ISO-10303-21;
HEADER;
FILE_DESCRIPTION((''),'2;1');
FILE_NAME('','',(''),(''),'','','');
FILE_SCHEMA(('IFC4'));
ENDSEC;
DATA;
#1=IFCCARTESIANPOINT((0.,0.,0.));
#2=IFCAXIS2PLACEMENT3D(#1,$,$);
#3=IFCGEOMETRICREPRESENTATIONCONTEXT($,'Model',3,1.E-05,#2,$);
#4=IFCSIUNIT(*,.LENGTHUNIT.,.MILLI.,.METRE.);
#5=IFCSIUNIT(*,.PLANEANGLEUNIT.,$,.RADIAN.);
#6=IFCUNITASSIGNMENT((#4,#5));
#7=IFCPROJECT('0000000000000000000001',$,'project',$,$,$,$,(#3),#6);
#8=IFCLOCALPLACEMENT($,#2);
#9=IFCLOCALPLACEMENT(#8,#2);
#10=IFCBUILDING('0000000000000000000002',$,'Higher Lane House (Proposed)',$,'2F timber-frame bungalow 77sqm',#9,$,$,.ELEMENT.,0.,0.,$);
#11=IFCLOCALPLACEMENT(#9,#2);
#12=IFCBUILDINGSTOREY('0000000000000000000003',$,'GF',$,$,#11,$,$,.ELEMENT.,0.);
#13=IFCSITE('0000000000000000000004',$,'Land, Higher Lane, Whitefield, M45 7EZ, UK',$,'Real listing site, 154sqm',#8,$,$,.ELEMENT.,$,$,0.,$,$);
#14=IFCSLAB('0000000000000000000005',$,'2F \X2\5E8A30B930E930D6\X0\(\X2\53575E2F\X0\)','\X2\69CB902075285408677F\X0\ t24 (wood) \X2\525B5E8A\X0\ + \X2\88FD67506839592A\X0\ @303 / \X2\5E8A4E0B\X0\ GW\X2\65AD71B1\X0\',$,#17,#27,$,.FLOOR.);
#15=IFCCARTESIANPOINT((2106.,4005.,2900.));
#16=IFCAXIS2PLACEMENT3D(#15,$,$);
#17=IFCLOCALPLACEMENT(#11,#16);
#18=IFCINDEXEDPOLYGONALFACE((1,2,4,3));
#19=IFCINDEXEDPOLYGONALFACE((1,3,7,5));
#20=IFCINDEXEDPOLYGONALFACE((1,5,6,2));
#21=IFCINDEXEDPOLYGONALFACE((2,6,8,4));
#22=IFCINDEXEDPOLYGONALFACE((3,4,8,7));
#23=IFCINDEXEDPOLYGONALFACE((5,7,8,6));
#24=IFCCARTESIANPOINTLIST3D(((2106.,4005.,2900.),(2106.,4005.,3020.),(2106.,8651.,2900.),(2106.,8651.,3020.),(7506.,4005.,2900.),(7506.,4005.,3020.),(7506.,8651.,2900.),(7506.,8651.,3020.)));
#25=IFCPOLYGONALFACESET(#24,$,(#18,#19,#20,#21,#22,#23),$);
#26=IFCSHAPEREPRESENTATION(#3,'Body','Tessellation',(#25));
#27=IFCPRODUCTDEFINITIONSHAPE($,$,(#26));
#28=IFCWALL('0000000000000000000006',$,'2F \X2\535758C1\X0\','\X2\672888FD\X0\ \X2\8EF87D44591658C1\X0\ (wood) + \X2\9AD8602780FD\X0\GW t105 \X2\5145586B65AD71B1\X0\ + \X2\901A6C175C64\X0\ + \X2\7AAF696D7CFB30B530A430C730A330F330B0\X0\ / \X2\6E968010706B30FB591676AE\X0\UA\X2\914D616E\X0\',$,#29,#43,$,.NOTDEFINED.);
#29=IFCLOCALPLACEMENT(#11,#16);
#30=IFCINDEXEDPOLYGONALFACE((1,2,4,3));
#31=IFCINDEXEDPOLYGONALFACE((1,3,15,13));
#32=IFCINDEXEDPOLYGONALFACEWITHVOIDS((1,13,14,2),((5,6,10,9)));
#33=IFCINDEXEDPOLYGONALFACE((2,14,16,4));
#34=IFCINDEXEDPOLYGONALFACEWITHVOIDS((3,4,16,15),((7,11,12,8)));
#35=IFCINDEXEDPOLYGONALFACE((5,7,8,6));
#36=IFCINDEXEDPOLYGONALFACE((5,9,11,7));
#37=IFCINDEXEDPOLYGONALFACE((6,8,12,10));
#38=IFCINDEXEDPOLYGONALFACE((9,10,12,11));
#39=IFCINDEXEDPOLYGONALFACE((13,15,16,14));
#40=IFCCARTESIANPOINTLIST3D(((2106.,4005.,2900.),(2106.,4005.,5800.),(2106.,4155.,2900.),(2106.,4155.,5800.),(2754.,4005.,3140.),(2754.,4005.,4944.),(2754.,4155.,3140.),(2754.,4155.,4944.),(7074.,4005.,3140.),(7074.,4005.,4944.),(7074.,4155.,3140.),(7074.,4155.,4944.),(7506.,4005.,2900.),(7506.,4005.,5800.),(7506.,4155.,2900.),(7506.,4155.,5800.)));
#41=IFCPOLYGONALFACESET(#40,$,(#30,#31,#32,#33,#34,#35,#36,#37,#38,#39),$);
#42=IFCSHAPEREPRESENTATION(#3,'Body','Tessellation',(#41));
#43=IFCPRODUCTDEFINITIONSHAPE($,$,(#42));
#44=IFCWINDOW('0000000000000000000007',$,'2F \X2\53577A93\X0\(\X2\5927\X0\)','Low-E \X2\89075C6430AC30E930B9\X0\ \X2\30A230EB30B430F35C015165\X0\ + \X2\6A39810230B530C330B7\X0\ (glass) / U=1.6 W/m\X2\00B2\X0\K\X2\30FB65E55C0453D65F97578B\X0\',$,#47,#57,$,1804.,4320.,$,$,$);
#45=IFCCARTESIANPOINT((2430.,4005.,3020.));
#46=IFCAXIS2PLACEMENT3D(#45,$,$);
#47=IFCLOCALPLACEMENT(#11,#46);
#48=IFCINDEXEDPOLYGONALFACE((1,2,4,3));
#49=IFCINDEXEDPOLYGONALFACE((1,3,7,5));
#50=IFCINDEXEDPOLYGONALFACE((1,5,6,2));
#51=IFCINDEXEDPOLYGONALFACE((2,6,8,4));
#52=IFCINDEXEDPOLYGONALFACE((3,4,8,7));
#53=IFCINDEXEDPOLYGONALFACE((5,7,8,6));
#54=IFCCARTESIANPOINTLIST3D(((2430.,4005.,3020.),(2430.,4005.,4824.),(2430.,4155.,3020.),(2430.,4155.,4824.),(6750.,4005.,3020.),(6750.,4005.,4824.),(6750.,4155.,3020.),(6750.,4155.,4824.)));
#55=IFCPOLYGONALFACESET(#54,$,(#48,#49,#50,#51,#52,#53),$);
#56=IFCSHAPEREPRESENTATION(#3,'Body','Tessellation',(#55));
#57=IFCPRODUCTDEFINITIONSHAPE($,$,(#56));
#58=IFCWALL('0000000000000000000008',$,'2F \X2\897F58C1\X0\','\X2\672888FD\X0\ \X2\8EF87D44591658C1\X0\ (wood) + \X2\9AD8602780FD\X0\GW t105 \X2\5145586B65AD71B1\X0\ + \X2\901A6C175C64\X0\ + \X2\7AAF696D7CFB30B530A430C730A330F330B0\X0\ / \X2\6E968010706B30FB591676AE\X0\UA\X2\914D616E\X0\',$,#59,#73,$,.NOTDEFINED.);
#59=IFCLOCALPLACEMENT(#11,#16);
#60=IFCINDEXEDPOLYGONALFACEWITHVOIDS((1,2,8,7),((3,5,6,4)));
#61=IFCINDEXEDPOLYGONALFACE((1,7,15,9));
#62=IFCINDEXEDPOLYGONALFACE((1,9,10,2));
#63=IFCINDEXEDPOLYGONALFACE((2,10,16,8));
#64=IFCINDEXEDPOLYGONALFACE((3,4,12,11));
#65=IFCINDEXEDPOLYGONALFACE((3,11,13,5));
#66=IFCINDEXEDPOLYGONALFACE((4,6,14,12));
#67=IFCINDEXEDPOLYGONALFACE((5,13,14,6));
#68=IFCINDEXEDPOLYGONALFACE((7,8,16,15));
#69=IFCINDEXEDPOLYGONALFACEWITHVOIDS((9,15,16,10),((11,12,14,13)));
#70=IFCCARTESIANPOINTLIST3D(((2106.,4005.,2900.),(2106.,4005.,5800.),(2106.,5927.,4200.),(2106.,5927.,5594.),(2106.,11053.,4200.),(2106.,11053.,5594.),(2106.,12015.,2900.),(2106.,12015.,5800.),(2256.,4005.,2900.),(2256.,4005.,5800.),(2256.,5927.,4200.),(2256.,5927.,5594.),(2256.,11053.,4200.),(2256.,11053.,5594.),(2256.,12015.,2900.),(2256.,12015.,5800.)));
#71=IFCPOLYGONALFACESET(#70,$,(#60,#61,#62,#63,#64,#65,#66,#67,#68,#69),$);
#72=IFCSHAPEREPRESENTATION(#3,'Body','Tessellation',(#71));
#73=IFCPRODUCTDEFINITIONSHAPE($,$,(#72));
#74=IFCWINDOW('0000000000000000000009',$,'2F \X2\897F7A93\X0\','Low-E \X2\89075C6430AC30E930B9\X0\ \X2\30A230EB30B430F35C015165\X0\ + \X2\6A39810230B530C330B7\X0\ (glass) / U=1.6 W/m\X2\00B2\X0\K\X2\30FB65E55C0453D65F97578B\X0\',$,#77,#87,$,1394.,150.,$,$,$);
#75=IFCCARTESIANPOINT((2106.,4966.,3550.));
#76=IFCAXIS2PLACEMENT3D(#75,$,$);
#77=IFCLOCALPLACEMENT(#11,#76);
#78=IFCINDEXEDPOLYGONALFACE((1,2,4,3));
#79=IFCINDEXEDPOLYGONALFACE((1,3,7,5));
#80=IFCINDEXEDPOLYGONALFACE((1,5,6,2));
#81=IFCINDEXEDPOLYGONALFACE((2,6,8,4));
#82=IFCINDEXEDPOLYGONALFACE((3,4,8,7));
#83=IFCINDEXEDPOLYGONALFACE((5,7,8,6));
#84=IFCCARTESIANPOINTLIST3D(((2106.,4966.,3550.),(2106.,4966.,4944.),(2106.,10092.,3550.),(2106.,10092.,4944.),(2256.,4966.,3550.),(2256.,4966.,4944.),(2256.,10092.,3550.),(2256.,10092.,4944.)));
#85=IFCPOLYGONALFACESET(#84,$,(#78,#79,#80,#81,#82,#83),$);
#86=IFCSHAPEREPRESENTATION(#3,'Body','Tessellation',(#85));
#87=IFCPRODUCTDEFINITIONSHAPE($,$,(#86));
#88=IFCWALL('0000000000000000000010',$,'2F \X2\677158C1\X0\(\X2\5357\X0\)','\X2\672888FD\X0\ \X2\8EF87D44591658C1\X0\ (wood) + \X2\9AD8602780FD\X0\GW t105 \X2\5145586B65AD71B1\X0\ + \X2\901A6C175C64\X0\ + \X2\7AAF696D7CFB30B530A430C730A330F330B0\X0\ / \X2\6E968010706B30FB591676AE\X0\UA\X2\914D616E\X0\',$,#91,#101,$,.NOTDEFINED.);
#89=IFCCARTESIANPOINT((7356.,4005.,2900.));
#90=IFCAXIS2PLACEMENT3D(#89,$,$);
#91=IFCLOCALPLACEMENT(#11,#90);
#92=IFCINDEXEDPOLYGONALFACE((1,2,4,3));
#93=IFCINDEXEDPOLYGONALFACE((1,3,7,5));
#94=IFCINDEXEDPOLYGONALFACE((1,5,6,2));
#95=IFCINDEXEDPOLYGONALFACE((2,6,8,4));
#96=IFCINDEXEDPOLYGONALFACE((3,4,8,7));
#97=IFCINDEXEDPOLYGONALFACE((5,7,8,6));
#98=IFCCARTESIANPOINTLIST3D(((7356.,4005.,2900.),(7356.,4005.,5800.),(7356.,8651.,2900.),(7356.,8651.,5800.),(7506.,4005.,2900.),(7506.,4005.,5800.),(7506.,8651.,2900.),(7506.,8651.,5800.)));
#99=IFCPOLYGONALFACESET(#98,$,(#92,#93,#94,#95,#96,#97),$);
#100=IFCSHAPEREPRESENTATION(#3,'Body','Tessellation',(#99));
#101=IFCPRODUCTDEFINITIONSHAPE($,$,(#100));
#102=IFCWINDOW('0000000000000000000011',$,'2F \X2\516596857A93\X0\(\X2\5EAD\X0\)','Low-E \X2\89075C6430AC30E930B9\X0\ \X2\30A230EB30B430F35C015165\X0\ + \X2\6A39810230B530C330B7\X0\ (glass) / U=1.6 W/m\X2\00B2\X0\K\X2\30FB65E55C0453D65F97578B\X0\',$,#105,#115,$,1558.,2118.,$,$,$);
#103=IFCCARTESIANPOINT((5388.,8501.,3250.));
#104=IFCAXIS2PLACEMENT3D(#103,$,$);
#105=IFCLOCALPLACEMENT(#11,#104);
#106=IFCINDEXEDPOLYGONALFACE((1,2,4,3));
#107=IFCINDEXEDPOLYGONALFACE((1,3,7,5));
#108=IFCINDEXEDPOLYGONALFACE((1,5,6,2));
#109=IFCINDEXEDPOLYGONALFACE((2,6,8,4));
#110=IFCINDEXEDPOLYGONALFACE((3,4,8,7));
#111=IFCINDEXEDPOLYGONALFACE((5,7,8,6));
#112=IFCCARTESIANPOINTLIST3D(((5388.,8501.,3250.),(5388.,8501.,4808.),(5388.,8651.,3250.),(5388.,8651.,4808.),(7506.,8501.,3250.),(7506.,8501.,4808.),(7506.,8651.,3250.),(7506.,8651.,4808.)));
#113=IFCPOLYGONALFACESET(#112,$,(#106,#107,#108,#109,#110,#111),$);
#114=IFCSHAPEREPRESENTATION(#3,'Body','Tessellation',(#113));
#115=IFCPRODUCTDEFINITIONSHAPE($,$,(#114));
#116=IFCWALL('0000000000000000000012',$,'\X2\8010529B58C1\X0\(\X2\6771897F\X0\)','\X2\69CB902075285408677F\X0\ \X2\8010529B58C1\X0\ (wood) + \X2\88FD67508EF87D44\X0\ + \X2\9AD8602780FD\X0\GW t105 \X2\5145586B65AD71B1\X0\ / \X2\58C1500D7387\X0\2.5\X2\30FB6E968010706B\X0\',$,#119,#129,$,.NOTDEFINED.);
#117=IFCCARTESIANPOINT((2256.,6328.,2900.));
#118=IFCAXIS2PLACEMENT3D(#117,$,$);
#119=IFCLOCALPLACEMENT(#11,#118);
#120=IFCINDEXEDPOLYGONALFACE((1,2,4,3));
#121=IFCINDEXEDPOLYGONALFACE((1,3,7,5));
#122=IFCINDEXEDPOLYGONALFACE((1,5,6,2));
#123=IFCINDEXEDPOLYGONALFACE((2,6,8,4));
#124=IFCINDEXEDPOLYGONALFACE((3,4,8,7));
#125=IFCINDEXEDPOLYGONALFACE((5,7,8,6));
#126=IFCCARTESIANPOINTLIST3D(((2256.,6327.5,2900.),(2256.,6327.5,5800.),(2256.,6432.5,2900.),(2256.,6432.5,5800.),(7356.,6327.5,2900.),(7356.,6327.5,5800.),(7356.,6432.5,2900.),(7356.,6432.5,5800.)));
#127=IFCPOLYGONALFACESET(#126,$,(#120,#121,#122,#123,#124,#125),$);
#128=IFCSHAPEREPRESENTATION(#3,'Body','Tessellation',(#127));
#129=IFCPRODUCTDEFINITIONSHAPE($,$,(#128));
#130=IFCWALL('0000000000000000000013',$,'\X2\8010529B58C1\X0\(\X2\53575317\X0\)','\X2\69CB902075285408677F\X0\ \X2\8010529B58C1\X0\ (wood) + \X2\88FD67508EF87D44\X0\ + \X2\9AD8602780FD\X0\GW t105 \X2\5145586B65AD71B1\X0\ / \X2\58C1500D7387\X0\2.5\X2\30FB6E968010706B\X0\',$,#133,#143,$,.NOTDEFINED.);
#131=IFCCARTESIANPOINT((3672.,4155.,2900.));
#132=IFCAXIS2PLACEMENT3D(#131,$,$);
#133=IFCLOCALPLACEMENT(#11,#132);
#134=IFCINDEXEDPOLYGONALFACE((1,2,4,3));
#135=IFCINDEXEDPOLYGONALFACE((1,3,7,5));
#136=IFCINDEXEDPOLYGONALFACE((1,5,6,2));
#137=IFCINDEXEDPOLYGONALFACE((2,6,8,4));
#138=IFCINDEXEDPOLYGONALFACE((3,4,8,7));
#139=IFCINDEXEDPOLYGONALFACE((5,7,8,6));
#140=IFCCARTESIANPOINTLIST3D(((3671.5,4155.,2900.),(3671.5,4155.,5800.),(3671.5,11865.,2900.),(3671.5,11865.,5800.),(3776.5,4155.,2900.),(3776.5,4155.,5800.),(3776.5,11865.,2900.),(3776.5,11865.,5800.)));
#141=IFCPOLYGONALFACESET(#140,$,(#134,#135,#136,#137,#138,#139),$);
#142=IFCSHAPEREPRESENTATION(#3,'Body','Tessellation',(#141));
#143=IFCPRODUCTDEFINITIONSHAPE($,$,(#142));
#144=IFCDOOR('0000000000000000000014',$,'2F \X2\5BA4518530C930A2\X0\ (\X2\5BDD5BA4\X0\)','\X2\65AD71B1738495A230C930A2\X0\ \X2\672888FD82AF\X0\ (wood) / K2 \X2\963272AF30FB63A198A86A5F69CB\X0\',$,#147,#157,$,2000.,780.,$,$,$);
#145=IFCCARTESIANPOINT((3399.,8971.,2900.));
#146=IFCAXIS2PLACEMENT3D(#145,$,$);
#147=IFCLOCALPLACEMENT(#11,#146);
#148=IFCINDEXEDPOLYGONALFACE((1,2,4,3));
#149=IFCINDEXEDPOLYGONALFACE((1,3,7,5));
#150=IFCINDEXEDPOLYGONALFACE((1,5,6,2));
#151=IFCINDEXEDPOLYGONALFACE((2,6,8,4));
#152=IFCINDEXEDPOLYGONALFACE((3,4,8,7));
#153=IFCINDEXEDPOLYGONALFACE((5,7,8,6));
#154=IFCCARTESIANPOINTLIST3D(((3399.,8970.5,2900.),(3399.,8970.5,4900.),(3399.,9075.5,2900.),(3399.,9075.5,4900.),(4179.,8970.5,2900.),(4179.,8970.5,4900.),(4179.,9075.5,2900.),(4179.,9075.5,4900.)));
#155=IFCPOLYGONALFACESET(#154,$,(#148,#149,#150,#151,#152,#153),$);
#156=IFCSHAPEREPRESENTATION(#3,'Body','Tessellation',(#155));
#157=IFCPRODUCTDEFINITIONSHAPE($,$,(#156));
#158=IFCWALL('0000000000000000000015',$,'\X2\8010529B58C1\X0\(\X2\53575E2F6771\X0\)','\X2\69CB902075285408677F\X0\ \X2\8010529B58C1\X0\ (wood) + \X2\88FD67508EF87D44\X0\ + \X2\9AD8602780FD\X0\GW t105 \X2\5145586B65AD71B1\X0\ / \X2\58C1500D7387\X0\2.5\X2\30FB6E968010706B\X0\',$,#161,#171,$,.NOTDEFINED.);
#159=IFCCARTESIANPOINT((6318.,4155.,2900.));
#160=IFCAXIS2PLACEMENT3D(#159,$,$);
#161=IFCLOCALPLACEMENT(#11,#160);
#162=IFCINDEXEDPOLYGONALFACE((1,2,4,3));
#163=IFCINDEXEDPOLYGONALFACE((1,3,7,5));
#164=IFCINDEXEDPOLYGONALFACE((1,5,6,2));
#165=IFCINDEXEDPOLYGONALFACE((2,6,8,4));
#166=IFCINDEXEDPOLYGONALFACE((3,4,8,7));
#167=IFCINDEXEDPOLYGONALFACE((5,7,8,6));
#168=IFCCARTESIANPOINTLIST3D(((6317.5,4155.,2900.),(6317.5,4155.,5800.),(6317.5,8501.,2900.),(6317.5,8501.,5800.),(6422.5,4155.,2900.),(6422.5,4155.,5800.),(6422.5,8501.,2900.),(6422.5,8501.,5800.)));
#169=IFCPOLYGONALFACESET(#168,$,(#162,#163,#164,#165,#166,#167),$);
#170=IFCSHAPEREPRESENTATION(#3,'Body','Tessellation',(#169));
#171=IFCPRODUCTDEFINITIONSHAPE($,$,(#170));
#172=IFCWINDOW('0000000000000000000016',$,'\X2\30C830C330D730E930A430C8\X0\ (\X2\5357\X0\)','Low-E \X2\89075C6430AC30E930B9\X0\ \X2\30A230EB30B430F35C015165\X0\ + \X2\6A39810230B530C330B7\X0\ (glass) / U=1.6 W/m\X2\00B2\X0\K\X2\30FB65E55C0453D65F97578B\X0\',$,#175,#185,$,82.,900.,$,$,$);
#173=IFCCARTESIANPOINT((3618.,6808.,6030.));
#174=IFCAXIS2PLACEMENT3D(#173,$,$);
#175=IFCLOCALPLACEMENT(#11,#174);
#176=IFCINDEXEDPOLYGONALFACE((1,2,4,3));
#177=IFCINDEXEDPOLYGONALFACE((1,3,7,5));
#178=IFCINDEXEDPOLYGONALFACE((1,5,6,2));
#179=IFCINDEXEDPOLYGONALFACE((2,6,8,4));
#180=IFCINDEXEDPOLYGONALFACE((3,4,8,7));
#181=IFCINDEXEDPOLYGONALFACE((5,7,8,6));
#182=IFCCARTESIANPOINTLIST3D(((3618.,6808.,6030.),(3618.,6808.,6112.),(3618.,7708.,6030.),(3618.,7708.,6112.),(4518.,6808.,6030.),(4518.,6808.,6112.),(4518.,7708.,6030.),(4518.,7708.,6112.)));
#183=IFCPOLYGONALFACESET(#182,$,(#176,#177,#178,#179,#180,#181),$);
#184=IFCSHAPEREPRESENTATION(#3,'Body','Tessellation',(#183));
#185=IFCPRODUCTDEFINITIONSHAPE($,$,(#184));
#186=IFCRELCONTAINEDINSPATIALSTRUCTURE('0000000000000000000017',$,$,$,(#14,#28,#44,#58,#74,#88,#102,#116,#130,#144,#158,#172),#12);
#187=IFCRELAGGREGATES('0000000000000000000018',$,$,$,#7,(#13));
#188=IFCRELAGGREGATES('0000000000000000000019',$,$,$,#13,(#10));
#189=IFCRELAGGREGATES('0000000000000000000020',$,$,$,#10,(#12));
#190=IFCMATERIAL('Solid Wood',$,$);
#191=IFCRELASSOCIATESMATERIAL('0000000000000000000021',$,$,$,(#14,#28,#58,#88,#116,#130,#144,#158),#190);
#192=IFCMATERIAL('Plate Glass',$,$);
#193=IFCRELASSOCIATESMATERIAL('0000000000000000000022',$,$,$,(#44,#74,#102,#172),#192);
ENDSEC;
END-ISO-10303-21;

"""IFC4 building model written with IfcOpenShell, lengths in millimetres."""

from ifc_helpers import new_model, si_unit, frame, frame_2d, origin, place, context, project, spatial, rectangle, extrude, material, element, fill, save


model = new_model("IFC4")

# Units and contexts
model_context = context("Model", 3, precision=1e-05, world=origin())
ifc_project = project(units=[si_unit("LENGTHUNIT", "METRE", prefix="MILLI"), si_unit("PLANEANGLEUNIT", "RADIAN")], contexts=[model_context])

# Site, building, storey
site_placement = place(None, origin())
site = spatial("IfcSite", under=ifc_project, at=site_placement, Name="Land, Higher Lane, Whitefield, M45 7EZ, UK", ObjectType="Real listing site, 154sqm", CompositionType="ELEMENT", RefElevation=0.0)
building_placement = place(site_placement, origin())
building = spatial("IfcBuilding", under=site, at=building_placement, Name="Higher Lane House (Proposed)", ObjectType="2F timber-frame bungalow 77sqm", CompositionType="ELEMENT", ElevationOfRefHeight=0.0, ElevationOfTerrain=0.0)
storey_placement = place(building_placement, origin())
storey = spatial("IfcBuildingStorey", under=building, at=storey_placement, Name="GF", CompositionType="ELEMENT", Elevation=0.0)

# Slab
ifc_material_1 = material(Name="Solid Wood")
slab_placement = place(storey_placement, frame((2106.0, 4005.0, 2900.0)))
element("IfcSlab", 1, at=slab_placement, inside=storey, material=ifc_material_1, Name="2F 床スラブ(南帯)", Description="構造用合板 t24 (wood) 剛床 + 製材根太 @303 / 床下 GW断熱", PredefinedType="FLOOR", context=model_context, shape_type="SweptSolid", body=[
    extrude(rectangle(XDim=5400.0, YDim=4646.0, at=frame_2d((2700.0, 2323.0))), frame((2106.0, 4005.0, 2900.0)), (0.0, 0.0, 1.0), 120.0),
])

# Walls, openings, windows
wall_1_placement = place(storey_placement, frame((2106.0, 4005.0, 2900.0)))
wall_1 = element("IfcWall", 2, at=wall_1_placement, inside=storey, material=ifc_material_1, Name="2F 南壁", Description="木製 軸組外壁 (wood) + 高性能GW t105 充填断熱 + 通気層 + 窯業系サイディング / 準耐火・外皮UA配慮", PredefinedType="NOTDEFINED", context=model_context, shape_type="SweptSolid", body=[
    extrude(rectangle(XDim=5400.0, YDim=150.0, at=frame_2d((2700.0, 75.0))), frame((2106.0, 4005.0, 2900.0)), (0.0, 0.0, 1.0), 2900.0),
])
opening_1_placement = place(storey_placement, frame((2430.0, 4005.0, 3020.0)))
opening_1 = element("IfcOpeningElement", 3, at=opening_1_placement, cuts=wall_1, PredefinedType="NOTDEFINED", context=model_context, shape_type="SweptSolid", body=[
    extrude(rectangle(XDim=4320.0, YDim=150.0, at=frame_2d((2160.0, 75.0))), frame((2430.0, 4005.0, 3020.0)), (0.0, 0.0, 1.0), 1804.0),
])
ifc_material_2 = material(Name="Plate Glass")
window_1_placement = place(storey_placement, frame((2430.0, 4005.0, 3020.0)))
window_1 = element("IfcWindow", 4, at=window_1_placement, inside=storey, material=ifc_material_2, Name="2F 南窓(大)", Description="Low-E 複層ガラス アルゴン封入 + 樹脂サッシ (glass) / U=1.6 W/m²K・日射取得型", OverallHeight=1804.0, OverallWidth=4320.0, context=model_context, shape_type="SweptSolid", body=[
    extrude(rectangle(XDim=4320.0, YDim=150.0, at=frame_2d((2160.0, 75.0))), frame((2430.0, 4005.0, 3020.0)), (0.0, 0.0, 1.0), 1804.0),
])
fill(opening_1, window_1)
wall_2_placement = place(storey_placement, frame((2106.0, 4005.0, 2900.0)))
wall_2 = element("IfcWall", 5, at=wall_2_placement, inside=storey, material=ifc_material_1, Name="2F 西壁", Description="木製 軸組外壁 (wood) + 高性能GW t105 充填断熱 + 通気層 + 窯業系サイディング / 準耐火・外皮UA配慮", PredefinedType="NOTDEFINED", context=model_context, shape_type="SweptSolid", body=[
    extrude(rectangle(XDim=150.0, YDim=8010.0, at=frame_2d((75.0, 4005.0))), frame((2106.0, 4005.0, 2900.0)), (0.0, 0.0, 1.0), 2900.0),
])
opening_2_placement = place(storey_placement, frame((2106.0, 4966.0, 3550.0)))
opening_2 = element("IfcOpeningElement", 6, at=opening_2_placement, cuts=wall_2, PredefinedType="NOTDEFINED", context=model_context, shape_type="SweptSolid", body=[
    extrude(rectangle(XDim=150.0, YDim=5126.0, at=frame_2d((75.0, 2563.0))), frame((2106.0, 4966.0, 3550.0)), (0.0, 0.0, 1.0), 1394.0),
])
window_2_placement = place(storey_placement, frame((2106.0, 4966.0, 3550.0)))
window_2 = element("IfcWindow", 7, at=window_2_placement, inside=storey, material=ifc_material_2, Name="2F 西窓", Description="Low-E 複層ガラス アルゴン封入 + 樹脂サッシ (glass) / U=1.6 W/m²K・日射取得型", OverallHeight=1394.0, OverallWidth=150.0, context=model_context, shape_type="SweptSolid", body=[
    extrude(rectangle(XDim=150.0, YDim=5126.0, at=frame_2d((75.0, 2563.0))), frame((2106.0, 4966.0, 3550.0)), (0.0, 0.0, 1.0), 1394.0),
])
fill(opening_2, window_2)
wall_3_placement = place(storey_placement, frame((7356.0, 4005.0, 2900.0)))
wall_3 = element("IfcWall", 8, at=wall_3_placement, inside=storey, material=ifc_material_1, Name="2F 東壁(南)", Description="木製 軸組外壁 (wood) + 高性能GW t105 充填断熱 + 通気層 + 窯業系サイディング / 準耐火・外皮UA配慮", PredefinedType="NOTDEFINED", context=model_context, shape_type="SweptSolid", body=[
    extrude(rectangle(XDim=150.0, YDim=4646.0, at=frame_2d((75.0, 2323.0))), frame((7356.0, 4005.0, 2900.0)), (0.0, 0.0, 1.0), 2900.0),
])
opening_3_placement = place(storey_placement, frame((5388.0, 8501.0, 3250.0)))
opening_3 = element("IfcOpeningElement", 9, at=opening_3_placement, cuts=wall_3, PredefinedType="NOTDEFINED", context=model_context, shape_type="SweptSolid", body=[
    extrude(rectangle(XDim=2118.0, YDim=150.0, at=frame_2d((1059.0, 75.0))), frame((5388.0, 8501.0, 3250.0)), (0.0, 0.0, 1.0), 1558.0),
])
window_3_placement = place(storey_placement, frame((5388.0, 8501.0, 3250.0)))
window_3 = element("IfcWindow", 10, at=window_3_placement, inside=storey, material=ifc_material_2, Name="2F 入隅窓(庭)", Description="Low-E 複層ガラス アルゴン封入 + 樹脂サッシ (glass) / U=1.6 W/m²K・日射取得型", OverallHeight=1558.0, OverallWidth=2118.0, context=model_context, shape_type="SweptSolid", body=[
    extrude(rectangle(XDim=2118.0, YDim=150.0, at=frame_2d((1059.0, 75.0))), frame((5388.0, 8501.0, 3250.0)), (0.0, 0.0, 1.0), 1558.0),
])
fill(opening_3, window_3)

# Wall
wall_4_placement = place(storey_placement, frame((2256.0, 6328.0, 2900.0)))
element("IfcWall", 11, at=wall_4_placement, inside=storey, material=ifc_material_1, Name="耐力壁(東西)", Description="構造用合板 耐力壁 (wood) + 製材軸組 + 高性能GW t105 充填断熱 / 壁倍率2.5・準耐火", PredefinedType="NOTDEFINED", context=model_context, shape_type="SweptSolid", body=[
    extrude(rectangle(XDim=5100.0, YDim=105.0, at=frame_2d((2550.0, 52.0))), frame((2256.0, 6328.0, 2900.0)), (0.0, 0.0, 1.0), 2900.0),
])

# Wall, opening, door
wall_5_placement = place(storey_placement, frame((3672.0, 4155.0, 2900.0)))
wall_5 = element("IfcWall", 12, at=wall_5_placement, inside=storey, material=ifc_material_1, Name="耐力壁(南北)", Description="構造用合板 耐力壁 (wood) + 製材軸組 + 高性能GW t105 充填断熱 / 壁倍率2.5・準耐火", PredefinedType="NOTDEFINED", context=model_context, shape_type="SweptSolid", body=[
    extrude(rectangle(XDim=105.0, YDim=7710.0, at=frame_2d((52.0, 3855.0))), frame((3672.0, 4155.0, 2900.0)), (0.0, 0.0, 1.0), 2900.0),
])
opening_4_placement = place(storey_placement, frame((3399.0, 8971.0, 2900.0)))
opening_4 = element("IfcOpeningElement", 13, at=opening_4_placement, cuts=wall_5, PredefinedType="NOTDEFINED", context=model_context, shape_type="SweptSolid", body=[
    extrude(rectangle(XDim=780.0, YDim=105.0, at=frame_2d((390.0, 52.0))), frame((3399.0, 8971.0, 2900.0)), (0.0, 0.0, 1.0), 2000.0),
])
door_placement = place(storey_placement, frame((3399.0, 8971.0, 2900.0)))
door = element("IfcDoor", 14, at=door_placement, inside=storey, material=ifc_material_1, Name="2F 室内ドア (寝室)", Description="断熱玄関ドア 木製芯 (wood) / K2 防犯・採風機構", OverallHeight=2000.0, OverallWidth=780.0, context=model_context, shape_type="SweptSolid", body=[
    extrude(rectangle(XDim=780.0, YDim=105.0, at=frame_2d((390.0, 52.0))), frame((3399.0, 8971.0, 2900.0)), (0.0, 0.0, 1.0), 2000.0),
])
fill(opening_4, door)

# Wall
wall_6_placement = place(storey_placement, frame((6318.0, 4155.0, 2900.0)))
element("IfcWall", 15, at=wall_6_placement, inside=storey, material=ifc_material_1, Name="耐力壁(南帯東)", Description="構造用合板 耐力壁 (wood) + 製材軸組 + 高性能GW t105 充填断熱 / 壁倍率2.5・準耐火", PredefinedType="NOTDEFINED", context=model_context, shape_type="SweptSolid", body=[
    extrude(rectangle(XDim=105.0, YDim=4346.0, at=frame_2d((52.0, 2173.0))), frame((6318.0, 4155.0, 2900.0)), (0.0, 0.0, 1.0), 2900.0),
])

# Window
window_4_placement = place(storey_placement, frame((3618.0, 6808.0, 6030.0)))
element("IfcWindow", 16, at=window_4_placement, inside=storey, material=ifc_material_2, Name="トップライト (南)", Description="Low-E 複層ガラス アルゴン封入 + 樹脂サッシ (glass) / U=1.6 W/m²K・日射取得型", OverallHeight=82.0, OverallWidth=900.0, context=model_context, shape_type="SweptSolid", body=[
    extrude(rectangle(XDim=900.0, YDim=900.0, at=frame_2d((450.0, 450.0))), frame((3618.0, 6808.0, 6030.0)), (0.0, 0.0, 1.0), 82.0),
])

save(model, "model.ifc")
